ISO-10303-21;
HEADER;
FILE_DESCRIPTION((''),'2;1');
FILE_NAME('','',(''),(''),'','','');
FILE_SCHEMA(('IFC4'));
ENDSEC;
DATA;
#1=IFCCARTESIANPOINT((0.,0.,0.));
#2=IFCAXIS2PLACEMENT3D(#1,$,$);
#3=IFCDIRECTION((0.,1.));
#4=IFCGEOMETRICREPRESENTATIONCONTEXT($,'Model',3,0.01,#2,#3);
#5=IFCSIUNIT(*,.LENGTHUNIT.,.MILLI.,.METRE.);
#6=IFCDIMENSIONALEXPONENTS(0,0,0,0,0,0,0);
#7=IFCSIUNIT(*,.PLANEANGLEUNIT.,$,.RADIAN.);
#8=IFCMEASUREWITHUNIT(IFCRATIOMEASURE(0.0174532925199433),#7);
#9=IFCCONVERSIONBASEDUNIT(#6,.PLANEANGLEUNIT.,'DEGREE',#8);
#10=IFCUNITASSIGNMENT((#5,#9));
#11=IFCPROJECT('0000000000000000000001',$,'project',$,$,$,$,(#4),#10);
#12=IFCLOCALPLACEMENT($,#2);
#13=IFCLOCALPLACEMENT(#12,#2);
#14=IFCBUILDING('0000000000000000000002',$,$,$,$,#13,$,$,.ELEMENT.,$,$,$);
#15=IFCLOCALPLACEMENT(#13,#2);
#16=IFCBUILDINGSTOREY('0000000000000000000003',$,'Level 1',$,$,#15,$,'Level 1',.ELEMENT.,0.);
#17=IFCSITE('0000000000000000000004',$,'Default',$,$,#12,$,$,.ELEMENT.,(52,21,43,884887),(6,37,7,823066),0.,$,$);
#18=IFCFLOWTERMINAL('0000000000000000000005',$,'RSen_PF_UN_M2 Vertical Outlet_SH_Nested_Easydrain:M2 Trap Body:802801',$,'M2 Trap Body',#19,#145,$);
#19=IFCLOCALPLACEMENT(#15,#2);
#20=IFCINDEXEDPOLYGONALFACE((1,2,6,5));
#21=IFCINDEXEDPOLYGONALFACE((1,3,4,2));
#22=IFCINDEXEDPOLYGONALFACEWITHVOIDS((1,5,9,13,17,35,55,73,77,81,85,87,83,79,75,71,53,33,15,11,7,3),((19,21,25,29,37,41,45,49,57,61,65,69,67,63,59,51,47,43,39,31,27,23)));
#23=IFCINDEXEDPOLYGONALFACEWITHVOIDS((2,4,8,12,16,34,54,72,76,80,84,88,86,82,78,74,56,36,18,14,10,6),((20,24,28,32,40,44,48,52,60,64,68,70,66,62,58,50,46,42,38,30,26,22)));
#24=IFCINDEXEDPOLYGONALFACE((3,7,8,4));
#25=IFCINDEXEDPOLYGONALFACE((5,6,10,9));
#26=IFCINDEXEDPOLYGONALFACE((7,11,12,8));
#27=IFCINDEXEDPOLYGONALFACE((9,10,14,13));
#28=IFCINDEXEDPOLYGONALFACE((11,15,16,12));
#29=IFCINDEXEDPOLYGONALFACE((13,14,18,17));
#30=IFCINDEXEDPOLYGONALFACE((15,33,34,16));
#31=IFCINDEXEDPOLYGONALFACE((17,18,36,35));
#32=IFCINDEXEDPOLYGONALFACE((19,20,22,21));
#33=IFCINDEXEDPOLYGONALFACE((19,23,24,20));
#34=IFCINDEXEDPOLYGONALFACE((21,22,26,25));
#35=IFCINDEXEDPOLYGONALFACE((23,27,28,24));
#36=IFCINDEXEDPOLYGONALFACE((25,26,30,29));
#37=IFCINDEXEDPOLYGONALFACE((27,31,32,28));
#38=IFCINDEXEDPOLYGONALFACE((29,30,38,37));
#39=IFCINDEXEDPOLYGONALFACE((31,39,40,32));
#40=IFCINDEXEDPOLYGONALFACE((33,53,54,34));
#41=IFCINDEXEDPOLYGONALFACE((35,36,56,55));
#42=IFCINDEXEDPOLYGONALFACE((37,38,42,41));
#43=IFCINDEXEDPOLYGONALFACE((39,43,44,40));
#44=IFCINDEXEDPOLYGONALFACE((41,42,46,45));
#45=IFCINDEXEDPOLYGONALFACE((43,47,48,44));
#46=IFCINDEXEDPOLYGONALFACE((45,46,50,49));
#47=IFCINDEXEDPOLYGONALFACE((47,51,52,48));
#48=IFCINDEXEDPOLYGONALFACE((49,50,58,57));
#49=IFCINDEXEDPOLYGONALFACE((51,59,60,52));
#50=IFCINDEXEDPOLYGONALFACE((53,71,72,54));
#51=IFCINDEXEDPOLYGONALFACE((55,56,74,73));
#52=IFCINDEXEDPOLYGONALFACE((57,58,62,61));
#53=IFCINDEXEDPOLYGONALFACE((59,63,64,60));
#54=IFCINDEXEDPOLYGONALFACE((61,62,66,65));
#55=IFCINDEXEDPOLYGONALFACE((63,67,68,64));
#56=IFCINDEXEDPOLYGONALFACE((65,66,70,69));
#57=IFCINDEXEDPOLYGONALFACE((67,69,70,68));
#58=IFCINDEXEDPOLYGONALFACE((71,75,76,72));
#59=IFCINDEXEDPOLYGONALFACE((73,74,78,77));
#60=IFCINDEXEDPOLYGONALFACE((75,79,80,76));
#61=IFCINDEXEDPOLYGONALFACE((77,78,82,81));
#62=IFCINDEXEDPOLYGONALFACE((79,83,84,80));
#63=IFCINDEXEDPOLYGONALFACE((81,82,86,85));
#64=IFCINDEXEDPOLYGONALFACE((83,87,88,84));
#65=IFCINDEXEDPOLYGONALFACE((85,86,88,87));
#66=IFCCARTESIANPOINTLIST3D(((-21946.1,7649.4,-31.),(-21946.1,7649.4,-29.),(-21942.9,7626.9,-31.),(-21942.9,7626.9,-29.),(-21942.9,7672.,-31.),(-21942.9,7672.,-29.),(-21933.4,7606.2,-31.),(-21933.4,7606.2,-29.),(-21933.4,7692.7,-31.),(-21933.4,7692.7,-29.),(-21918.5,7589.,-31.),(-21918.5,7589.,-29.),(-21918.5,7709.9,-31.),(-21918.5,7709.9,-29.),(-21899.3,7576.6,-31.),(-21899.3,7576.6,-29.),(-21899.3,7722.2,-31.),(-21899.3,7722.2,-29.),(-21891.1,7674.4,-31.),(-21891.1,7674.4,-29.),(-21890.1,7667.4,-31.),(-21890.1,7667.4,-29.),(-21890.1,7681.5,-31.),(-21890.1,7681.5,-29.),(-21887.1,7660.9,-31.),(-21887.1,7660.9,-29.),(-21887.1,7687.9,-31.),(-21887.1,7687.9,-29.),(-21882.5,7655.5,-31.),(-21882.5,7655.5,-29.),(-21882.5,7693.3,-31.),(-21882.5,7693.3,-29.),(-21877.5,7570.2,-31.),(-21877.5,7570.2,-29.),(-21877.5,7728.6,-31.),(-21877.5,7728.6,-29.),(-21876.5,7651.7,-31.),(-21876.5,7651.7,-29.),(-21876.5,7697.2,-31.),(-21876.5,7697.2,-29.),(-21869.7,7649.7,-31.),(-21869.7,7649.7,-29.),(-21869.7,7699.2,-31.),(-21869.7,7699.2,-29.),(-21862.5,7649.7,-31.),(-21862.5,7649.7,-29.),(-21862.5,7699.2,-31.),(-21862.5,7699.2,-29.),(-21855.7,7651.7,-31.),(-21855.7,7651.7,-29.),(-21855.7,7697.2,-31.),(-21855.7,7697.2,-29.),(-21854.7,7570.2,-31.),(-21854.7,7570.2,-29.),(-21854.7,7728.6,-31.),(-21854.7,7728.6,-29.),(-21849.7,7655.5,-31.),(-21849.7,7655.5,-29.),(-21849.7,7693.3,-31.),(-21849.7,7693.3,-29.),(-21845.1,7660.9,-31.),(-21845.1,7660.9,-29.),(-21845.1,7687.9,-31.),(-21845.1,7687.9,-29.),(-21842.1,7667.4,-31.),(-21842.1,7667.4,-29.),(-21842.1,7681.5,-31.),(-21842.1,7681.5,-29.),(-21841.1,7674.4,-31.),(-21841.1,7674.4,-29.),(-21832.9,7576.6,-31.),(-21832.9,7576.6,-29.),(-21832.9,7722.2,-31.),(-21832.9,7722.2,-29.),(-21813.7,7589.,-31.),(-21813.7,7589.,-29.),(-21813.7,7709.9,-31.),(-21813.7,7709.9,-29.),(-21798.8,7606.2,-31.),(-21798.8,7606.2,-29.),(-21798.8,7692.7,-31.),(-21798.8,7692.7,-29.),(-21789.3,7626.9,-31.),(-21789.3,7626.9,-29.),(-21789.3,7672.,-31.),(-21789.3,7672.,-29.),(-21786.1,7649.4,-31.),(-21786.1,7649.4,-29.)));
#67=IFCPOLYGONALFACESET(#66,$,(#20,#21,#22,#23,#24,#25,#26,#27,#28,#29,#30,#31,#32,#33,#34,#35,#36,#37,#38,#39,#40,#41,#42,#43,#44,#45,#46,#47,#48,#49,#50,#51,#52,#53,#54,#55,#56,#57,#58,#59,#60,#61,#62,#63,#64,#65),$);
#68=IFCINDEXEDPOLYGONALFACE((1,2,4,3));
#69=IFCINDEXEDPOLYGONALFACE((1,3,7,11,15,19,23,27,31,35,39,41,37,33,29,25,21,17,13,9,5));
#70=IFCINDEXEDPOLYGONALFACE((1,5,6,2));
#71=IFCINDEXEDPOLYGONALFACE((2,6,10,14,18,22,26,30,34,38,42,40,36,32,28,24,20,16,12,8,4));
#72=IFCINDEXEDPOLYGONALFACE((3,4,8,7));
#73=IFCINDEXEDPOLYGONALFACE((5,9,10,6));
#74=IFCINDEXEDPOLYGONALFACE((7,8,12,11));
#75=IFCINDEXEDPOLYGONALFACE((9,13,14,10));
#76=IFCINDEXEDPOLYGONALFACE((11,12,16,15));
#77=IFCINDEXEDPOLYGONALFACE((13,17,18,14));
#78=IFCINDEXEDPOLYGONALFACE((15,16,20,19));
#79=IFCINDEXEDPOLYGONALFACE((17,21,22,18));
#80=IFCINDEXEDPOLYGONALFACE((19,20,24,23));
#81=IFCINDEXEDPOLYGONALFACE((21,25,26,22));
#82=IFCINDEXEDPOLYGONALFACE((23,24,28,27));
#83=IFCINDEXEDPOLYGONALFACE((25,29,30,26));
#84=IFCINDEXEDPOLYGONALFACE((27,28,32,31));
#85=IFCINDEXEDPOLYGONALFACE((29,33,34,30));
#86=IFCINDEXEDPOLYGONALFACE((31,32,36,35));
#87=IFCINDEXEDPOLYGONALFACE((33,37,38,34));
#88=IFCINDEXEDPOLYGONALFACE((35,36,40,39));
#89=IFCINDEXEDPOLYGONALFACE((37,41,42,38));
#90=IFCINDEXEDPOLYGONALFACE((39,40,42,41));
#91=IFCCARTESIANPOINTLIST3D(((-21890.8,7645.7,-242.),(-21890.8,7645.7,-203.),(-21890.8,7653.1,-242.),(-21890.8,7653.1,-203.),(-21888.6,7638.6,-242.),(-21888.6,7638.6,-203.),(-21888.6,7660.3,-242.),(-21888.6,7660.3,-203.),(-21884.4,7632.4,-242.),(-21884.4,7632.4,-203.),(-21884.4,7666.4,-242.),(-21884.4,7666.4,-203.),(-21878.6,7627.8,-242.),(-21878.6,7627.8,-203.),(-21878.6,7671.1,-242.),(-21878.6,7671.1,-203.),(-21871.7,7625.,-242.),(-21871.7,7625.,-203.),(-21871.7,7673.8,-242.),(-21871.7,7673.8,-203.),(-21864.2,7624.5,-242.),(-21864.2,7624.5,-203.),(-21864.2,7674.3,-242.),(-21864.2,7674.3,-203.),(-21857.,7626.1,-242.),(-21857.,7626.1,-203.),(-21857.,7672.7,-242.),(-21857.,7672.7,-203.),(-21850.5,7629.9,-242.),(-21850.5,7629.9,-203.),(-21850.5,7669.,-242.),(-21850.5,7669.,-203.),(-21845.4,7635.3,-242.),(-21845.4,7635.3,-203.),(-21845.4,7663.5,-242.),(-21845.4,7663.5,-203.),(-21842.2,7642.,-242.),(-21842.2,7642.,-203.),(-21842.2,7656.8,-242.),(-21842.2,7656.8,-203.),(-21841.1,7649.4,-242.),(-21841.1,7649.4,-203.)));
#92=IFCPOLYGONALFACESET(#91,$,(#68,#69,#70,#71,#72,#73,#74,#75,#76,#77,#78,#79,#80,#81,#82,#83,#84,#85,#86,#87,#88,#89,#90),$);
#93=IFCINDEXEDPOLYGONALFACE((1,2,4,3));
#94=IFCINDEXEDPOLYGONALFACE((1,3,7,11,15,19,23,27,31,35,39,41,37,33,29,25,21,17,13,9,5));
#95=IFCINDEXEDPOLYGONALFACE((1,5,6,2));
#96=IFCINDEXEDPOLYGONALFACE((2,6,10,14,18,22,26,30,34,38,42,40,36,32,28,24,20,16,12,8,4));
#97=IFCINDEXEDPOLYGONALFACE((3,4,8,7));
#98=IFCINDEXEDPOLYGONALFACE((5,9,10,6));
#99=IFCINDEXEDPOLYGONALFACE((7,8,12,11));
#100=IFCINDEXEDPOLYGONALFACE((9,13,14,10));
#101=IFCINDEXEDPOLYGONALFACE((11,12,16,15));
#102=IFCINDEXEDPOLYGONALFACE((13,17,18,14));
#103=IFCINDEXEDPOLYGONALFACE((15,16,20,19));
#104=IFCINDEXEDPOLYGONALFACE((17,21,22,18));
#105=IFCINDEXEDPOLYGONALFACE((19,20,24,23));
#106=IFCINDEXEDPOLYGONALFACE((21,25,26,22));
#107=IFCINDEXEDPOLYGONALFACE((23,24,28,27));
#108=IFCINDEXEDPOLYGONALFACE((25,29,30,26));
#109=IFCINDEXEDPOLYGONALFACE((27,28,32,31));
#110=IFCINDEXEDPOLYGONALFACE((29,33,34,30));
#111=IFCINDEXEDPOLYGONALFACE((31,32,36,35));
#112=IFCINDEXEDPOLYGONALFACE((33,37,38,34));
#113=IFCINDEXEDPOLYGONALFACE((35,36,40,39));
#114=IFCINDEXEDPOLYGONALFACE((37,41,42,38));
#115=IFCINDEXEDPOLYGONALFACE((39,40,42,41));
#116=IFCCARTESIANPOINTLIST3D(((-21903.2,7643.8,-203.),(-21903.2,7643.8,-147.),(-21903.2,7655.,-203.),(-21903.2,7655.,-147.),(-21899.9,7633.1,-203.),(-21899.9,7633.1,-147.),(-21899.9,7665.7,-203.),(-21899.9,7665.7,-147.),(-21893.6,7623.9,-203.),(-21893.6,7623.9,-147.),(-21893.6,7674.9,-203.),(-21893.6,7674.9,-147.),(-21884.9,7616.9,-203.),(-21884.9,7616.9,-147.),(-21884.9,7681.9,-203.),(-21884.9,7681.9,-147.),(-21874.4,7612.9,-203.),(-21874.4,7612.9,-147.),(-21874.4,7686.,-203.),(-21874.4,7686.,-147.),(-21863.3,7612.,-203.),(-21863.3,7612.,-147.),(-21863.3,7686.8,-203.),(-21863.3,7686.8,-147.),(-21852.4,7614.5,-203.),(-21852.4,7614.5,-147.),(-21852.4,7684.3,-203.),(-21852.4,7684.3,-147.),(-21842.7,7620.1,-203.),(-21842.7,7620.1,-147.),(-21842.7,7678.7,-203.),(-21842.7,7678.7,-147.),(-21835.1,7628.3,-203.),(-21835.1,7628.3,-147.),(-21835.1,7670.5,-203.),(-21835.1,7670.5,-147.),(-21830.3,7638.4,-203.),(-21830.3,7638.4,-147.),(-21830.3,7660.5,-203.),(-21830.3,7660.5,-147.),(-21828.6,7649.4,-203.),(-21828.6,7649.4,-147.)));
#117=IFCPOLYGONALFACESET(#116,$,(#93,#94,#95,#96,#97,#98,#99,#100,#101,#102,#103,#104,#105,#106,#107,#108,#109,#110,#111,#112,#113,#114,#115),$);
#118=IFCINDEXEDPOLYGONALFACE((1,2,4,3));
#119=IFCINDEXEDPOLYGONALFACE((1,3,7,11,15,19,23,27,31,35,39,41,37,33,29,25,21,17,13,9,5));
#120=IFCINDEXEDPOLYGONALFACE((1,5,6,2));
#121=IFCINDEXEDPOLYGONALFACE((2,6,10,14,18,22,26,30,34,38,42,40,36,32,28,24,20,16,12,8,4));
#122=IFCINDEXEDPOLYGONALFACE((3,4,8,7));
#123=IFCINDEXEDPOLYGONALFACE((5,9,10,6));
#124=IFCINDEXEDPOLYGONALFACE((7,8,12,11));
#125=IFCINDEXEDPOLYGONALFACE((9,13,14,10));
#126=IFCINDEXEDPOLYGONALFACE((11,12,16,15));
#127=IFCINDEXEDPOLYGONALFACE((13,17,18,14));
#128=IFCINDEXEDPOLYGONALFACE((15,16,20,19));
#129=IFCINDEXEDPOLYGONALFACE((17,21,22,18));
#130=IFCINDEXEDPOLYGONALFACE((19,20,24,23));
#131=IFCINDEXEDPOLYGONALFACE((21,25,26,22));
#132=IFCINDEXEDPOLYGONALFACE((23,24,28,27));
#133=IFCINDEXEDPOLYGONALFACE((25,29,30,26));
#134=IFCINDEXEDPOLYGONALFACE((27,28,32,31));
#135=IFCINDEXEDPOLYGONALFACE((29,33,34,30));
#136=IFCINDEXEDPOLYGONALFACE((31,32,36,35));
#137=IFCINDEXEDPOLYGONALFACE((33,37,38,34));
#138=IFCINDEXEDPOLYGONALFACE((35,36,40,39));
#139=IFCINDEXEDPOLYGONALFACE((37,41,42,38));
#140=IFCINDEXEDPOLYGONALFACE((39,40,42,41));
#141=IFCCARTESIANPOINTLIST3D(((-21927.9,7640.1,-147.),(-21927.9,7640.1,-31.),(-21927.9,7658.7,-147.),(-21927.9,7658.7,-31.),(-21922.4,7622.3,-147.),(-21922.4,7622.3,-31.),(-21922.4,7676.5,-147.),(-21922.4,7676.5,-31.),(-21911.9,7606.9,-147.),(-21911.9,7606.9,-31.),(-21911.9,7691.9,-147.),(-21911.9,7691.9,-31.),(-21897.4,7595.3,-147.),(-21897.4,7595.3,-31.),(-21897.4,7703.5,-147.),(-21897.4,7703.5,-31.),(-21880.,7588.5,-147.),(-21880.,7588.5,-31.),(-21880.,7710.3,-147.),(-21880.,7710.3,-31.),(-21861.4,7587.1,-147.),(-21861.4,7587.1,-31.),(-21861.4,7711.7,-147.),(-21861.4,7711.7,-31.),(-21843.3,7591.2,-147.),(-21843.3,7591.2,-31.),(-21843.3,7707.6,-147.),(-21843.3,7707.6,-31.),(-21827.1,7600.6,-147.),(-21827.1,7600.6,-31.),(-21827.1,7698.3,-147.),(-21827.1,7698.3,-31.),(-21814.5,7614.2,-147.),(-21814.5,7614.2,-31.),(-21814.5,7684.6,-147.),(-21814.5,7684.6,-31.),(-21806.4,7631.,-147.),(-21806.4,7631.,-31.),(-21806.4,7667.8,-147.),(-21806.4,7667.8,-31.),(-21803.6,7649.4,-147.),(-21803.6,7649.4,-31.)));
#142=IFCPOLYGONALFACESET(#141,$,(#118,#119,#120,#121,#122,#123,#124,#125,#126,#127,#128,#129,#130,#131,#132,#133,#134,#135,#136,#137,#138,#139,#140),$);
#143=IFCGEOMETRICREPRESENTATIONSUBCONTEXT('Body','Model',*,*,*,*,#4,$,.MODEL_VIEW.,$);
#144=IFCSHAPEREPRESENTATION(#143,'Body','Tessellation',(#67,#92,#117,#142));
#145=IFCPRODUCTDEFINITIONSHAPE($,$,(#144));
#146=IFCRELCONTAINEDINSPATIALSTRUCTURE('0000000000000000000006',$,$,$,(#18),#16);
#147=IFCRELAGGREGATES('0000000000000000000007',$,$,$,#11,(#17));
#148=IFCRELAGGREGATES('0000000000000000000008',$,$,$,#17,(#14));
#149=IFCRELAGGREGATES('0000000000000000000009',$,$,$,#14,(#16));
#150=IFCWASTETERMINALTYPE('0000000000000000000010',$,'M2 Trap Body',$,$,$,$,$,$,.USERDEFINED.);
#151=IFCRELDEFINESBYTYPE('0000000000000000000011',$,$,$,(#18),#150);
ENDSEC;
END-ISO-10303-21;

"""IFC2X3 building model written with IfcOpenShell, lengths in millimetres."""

from ifc_helpers import new_model, entity, si_unit, converted_unit, direction, frame, frame_2d, origin, origin_2d_with_axis, place, context, subcontext, project, spatial, circle_curve, parameter, trimmed, segment, composite_curve, circle, outline, extrude, source, transform, mapped, type_object, type_shapes, element, save


model = new_model("IFC2X3")

# Units and contexts
model_context = context("Model", 3, precision=0.01, world=origin(), true_north=direction((0.0, 1.0)))
body_context = subcontext(model_context, "Body", "Model", "MODEL_VIEW")
ifc_project = project(units=[si_unit("LENGTHUNIT", "METRE", prefix="MILLI"), converted_unit("PLANEANGLEUNIT", "DEGREE", entity("IfcRatioMeasure", 0.0174532925199433), si_unit("PLANEANGLEUNIT", "RADIAN"), dimensions=[0, 0, 0, 0, 0, 0, 0])], contexts=[model_context])

# Site, building, storey
site_placement = place(None, origin())
site = spatial("IfcSite", under=ifc_project, at=site_placement, Name="Default", CompositionType="ELEMENT", RefLatitude=(52, 21, 43, 884887), RefLongitude=(6, 37, 7, 823066), RefElevation=0.0)
building_placement = place(site_placement, origin())
building = spatial("IfcBuilding", under=site, at=building_placement, CompositionType="ELEMENT")
storey_placement = place(building_placement, origin())
storey = spatial("IfcBuildingStorey", under=building, at=storey_placement, Name="Level 1", LongName="Level 1", CompositionType="ELEMENT", Elevation=0.0)

# Flow terminal
waste_terminal_type_1 = type_object("IfcWasteTerminalType", Name="M2 Trap Body", PredefinedType="USERDEFINED")
shared_shape_1 = source(origin(), body_context, "Body", "SweptSolid", [
    extrude(outline(composite_curve([segment(trimmed(circle_curve(origin_2d_with_axis(), 80.0), [parameter(0.0)], [parameter(180.0)], True, "PARAMETER"), True, "CONTINUOUS"), segment(trimmed(circle_curve(origin_2d_with_axis(), 80.0), [parameter(180.0)], [parameter(360.0)], True, "PARAMETER"), True, "CONTINUOUS")], self_intersect=False), holes=[composite_curve([segment(trimmed(circle_curve(frame_2d((0.0, 25.0), x_axis=(1.0, 0.0)), 25.0), [parameter(180.0)], [parameter(360.0)], True, "PARAMETER"), False, "CONTINUOUS"), segment(trimmed(circle_curve(frame_2d((0.0, 25.0), x_axis=(1.0, 0.0)), 25.0), [parameter(0.0)], [parameter(180.0)], True, "PARAMETER"), False, "CONTINUOUS")], self_intersect=False)]), frame((0.0, -25.0, -2.0)), (0.0, 0.0, 1.0), 2.0),
    extrude(circle(Radius=25.0, at=frame_2d((0.0, 0.0), x_axis=(1.0, 0.0))), frame((0.0, -25.0, -213.0)), (0.0, 0.0, 1.0), 39.0),
    extrude(circle(Radius=37.5, at=frame_2d((0.0, 0.0), x_axis=(1.0, 0.0))), frame((0.0, -25.0, -174.0)), (0.0, 0.0, 1.0), 56.0),
    extrude(circle(Radius=62.5, at=frame_2d((0.0, 0.0), x_axis=(1.0, 0.0))), frame((0.0, -25.0, -118.0)), (0.0, 0.0, 1.0), 116.0),
])
type_shapes(waste_terminal_type_1, [shared_shape_1])
for number, where, name in (
    (1, (-21866.1, 7674.4, -29.0), "RSen_PF_UN_M2 Vertical Outlet_SH_Nested_Easydrain:M2 Trap Body:802801"),
):
    element("IfcFlowTerminal", number, at=place(storey_placement, frame(where)), inside=storey, type_object=waste_terminal_type_1, Name=name, ObjectType="M2 Trap Body", context=body_context, shape_type="MappedRepresentation", body=[
        mapped(shared_shape_1, transform((0.0, 0.0, 0.0), scale=1.0)),
    ])

save(model, "model.ifc")
